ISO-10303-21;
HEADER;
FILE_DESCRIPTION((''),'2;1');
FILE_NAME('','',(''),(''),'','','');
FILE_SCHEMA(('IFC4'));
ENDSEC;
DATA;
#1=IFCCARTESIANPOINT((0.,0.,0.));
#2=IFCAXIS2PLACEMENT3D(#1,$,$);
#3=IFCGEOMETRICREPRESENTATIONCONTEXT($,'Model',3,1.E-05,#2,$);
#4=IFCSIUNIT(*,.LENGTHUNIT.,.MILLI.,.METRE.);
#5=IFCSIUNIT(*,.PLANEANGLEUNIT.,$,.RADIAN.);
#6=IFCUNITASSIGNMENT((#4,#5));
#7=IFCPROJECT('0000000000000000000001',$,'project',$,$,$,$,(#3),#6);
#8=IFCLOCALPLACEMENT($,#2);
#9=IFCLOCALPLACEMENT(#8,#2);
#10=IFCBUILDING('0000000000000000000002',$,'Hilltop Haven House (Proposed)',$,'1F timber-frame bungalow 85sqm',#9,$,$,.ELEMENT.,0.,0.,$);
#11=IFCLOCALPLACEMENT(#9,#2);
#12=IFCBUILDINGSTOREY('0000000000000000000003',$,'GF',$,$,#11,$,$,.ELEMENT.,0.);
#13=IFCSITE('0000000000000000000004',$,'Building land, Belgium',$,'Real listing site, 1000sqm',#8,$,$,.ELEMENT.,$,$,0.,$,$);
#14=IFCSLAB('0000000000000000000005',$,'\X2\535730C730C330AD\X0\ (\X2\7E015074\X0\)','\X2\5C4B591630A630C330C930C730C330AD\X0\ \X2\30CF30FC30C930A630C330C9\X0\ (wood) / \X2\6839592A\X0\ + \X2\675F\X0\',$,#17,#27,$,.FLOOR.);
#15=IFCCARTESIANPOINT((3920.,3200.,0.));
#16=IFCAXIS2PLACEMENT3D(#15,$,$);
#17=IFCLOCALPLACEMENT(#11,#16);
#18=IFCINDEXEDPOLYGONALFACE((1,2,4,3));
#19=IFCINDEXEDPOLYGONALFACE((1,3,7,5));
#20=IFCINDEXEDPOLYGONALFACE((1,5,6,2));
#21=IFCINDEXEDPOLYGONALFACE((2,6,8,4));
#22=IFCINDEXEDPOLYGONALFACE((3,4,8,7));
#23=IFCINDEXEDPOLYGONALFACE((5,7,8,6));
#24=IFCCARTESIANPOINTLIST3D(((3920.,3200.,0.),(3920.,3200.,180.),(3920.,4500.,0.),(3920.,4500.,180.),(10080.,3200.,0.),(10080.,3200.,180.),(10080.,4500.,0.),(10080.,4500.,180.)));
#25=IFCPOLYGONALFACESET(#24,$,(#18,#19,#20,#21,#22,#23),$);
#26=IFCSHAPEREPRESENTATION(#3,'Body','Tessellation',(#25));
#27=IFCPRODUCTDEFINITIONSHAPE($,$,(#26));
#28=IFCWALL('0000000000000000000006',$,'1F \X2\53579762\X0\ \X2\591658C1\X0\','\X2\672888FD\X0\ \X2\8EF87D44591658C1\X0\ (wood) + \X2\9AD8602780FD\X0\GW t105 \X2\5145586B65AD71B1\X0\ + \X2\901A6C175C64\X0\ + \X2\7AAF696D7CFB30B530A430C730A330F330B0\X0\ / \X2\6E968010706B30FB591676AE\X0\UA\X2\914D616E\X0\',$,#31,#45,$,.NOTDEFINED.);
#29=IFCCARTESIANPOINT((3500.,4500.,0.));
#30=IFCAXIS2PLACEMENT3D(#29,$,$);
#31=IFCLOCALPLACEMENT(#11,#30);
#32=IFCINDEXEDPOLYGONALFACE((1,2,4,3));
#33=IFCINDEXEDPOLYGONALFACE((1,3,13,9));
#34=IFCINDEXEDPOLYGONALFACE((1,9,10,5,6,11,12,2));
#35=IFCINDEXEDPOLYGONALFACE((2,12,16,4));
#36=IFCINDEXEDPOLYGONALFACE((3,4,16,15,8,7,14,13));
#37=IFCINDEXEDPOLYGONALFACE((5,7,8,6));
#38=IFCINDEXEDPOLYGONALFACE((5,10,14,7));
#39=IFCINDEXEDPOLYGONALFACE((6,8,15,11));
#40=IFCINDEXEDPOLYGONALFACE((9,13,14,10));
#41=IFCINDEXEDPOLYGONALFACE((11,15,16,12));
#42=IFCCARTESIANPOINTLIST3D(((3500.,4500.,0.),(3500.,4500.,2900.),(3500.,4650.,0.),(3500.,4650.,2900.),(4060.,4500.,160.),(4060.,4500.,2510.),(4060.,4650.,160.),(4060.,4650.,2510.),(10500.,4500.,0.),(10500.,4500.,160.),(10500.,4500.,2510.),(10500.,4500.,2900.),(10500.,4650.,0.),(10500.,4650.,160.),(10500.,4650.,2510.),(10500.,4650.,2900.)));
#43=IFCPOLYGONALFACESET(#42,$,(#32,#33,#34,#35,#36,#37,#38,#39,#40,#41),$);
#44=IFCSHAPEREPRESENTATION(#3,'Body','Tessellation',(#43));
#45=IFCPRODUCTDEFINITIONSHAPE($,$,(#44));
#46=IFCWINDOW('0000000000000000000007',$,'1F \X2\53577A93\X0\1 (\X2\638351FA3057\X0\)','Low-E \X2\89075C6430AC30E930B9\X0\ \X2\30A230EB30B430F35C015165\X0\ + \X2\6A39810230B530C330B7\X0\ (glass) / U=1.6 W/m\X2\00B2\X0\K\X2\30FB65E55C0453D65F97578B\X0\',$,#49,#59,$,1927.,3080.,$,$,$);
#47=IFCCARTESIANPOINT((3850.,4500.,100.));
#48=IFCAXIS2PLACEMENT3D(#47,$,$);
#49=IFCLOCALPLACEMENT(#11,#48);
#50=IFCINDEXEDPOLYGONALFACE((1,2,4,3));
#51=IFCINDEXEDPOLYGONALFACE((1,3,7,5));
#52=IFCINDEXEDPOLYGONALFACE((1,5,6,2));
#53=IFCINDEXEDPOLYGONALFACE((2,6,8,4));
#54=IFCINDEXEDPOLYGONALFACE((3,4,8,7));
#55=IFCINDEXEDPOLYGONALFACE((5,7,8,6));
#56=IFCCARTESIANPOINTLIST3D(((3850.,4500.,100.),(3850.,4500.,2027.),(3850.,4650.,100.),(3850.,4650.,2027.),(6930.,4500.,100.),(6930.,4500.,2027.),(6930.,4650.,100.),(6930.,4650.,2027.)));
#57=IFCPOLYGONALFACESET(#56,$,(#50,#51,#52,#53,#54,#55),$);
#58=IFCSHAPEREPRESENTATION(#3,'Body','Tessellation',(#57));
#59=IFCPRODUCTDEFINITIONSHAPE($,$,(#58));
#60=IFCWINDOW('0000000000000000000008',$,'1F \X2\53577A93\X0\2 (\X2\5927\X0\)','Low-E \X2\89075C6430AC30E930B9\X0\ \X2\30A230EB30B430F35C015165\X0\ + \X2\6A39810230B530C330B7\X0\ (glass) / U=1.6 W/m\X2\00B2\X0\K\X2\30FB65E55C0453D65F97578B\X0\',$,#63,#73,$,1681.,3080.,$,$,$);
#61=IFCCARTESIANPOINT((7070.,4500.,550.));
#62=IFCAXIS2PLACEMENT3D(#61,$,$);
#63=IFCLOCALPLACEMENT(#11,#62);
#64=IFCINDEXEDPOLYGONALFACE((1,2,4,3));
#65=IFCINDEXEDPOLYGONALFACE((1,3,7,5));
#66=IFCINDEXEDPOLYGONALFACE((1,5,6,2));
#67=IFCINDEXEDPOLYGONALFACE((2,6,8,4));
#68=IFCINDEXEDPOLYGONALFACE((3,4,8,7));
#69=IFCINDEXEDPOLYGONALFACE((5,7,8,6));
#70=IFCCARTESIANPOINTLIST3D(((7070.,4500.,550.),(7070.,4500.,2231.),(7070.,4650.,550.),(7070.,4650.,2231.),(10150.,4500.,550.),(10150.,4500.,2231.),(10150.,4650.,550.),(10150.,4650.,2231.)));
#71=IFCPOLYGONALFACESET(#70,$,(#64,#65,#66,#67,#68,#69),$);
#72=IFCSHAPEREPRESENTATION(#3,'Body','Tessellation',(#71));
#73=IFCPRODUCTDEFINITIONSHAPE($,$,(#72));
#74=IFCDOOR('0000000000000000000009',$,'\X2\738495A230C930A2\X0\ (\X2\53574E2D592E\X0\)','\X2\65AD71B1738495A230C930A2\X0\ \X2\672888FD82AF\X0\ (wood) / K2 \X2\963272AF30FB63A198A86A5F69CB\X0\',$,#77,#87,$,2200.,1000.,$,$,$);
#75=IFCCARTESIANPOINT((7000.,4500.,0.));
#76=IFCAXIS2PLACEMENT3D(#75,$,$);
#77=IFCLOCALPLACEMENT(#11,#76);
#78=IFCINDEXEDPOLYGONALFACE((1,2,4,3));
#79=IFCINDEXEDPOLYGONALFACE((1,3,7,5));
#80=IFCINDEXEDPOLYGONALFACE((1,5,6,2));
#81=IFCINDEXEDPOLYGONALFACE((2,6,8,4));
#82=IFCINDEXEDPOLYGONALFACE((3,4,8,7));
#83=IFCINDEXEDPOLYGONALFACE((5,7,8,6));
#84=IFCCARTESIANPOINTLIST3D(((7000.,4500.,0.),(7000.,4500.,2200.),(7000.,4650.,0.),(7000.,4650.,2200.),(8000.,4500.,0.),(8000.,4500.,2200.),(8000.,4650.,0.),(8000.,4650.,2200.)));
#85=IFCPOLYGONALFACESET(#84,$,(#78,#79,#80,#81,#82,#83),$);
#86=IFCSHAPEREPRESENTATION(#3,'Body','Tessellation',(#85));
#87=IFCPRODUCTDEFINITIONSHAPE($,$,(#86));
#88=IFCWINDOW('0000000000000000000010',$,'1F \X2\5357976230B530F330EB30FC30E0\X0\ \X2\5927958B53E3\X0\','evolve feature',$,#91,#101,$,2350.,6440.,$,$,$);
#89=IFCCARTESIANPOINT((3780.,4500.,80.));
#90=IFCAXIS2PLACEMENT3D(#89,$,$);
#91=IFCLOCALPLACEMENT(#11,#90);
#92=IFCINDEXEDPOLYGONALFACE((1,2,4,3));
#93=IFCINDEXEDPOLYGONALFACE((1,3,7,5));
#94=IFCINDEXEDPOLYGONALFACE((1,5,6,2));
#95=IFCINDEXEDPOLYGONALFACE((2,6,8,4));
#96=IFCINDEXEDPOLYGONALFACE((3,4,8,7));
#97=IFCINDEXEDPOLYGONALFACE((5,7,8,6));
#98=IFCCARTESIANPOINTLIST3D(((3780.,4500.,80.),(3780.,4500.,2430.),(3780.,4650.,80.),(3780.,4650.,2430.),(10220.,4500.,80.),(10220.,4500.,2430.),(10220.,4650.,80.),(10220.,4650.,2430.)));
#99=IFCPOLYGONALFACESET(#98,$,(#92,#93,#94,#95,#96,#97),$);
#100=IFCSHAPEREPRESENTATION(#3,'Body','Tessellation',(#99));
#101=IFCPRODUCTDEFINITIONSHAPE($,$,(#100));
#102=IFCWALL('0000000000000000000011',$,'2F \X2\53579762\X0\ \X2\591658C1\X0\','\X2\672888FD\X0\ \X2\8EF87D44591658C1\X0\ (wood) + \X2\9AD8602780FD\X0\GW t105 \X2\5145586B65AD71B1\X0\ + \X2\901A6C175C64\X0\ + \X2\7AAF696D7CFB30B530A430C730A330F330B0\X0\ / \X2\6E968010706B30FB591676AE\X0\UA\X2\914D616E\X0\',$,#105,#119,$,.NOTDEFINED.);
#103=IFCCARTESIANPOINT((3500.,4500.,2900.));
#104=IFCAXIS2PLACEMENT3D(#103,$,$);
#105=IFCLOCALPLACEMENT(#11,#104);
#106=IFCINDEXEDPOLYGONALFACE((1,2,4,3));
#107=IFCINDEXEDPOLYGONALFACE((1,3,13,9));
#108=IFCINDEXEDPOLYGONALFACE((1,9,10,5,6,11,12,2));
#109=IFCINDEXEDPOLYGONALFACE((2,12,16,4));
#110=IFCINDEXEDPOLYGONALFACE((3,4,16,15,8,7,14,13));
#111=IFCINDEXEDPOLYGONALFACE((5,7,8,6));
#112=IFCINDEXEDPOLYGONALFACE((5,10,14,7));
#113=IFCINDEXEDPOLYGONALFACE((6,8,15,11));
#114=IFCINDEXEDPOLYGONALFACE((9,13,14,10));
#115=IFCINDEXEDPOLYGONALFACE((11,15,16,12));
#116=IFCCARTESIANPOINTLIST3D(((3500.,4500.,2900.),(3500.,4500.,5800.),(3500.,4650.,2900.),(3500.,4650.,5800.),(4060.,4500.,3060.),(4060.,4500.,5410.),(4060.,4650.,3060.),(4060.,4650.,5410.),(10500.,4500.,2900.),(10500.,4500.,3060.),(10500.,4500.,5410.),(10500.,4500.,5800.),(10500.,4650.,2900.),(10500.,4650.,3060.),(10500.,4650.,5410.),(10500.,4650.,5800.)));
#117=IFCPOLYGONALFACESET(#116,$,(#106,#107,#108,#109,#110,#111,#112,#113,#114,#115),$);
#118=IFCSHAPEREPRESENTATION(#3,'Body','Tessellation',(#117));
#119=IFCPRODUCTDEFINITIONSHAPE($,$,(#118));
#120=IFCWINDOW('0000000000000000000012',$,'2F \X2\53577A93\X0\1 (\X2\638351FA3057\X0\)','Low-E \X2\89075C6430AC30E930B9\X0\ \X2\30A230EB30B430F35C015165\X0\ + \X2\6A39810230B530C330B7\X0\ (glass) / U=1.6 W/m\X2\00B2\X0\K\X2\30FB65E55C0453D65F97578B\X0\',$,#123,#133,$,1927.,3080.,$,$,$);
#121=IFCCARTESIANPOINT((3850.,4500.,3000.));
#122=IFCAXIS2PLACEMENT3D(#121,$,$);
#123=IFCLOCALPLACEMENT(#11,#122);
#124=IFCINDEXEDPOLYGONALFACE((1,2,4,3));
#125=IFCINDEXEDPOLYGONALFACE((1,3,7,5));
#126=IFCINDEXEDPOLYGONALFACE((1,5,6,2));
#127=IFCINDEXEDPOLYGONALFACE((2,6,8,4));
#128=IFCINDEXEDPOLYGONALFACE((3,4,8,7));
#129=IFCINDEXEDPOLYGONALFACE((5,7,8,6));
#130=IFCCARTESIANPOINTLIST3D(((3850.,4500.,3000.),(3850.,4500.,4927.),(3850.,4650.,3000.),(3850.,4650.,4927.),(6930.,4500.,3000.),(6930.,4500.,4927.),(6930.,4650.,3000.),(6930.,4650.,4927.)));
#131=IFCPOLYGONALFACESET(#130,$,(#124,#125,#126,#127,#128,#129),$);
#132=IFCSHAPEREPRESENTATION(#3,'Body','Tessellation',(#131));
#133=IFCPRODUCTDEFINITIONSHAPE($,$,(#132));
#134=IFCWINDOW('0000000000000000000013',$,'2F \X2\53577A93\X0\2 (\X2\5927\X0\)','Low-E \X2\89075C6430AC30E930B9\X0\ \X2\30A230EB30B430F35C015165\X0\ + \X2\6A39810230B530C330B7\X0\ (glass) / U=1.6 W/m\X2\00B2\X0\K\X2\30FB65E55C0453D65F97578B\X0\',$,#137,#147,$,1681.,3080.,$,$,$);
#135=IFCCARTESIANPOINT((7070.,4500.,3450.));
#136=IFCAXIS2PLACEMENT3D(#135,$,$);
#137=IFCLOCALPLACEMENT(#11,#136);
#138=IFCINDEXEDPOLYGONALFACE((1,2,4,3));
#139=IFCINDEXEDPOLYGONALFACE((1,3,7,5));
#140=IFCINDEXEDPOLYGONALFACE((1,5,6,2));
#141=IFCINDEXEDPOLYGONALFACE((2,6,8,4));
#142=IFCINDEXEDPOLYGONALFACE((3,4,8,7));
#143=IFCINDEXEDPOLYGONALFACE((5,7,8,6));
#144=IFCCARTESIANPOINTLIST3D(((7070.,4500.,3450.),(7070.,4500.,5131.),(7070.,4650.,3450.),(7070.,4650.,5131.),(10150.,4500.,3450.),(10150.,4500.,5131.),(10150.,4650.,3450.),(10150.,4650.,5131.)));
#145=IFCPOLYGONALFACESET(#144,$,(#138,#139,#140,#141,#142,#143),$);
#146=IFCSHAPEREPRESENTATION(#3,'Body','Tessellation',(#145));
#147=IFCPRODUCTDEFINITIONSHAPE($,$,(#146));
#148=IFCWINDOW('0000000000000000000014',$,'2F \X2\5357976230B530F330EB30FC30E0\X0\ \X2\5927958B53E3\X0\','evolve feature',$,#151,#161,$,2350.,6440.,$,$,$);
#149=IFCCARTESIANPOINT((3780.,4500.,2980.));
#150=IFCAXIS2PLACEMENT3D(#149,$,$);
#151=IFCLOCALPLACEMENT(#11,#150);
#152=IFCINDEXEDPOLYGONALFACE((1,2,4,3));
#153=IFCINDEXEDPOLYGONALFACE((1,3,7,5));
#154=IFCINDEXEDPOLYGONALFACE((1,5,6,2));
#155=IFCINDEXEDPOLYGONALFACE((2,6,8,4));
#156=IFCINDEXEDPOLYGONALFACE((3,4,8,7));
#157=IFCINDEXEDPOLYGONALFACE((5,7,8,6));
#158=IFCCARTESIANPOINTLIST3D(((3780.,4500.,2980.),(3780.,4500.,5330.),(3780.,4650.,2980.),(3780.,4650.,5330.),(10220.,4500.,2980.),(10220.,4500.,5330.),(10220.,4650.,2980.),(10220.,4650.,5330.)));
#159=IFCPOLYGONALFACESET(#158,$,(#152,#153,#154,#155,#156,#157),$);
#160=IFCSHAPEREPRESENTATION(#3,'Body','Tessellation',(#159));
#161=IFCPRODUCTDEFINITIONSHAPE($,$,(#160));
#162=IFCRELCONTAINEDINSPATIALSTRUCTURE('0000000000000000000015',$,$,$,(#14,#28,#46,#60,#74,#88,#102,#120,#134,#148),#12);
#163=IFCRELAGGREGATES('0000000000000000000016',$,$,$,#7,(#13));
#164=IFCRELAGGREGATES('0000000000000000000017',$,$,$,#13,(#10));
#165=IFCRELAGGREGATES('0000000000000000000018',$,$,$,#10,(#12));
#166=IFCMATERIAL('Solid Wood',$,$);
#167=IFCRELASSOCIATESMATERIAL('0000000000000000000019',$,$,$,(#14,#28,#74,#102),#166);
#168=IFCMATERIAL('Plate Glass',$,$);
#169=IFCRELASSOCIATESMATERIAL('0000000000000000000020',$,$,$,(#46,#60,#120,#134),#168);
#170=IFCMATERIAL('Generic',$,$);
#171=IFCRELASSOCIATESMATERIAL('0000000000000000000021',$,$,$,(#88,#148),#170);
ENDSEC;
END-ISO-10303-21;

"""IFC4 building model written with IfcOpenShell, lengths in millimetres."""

from ifc_helpers import new_model, si_unit, frame, frame_2d, origin, place, context, project, spatial, rectangle, extrude, material, element, fill, save


model = new_model("IFC4")

# Units and contexts
model_context = context("Model", 3, precision=1e-05, world=origin())
ifc_project = project(units=[si_unit("LENGTHUNIT", "METRE", prefix="MILLI"), si_unit("PLANEANGLEUNIT", "RADIAN")], contexts=[model_context])

# Site, building, storey
site_placement = place(None, origin())
site = spatial("IfcSite", under=ifc_project, at=site_placement, Name="Building land, Belgium", ObjectType="Real listing site, 1000sqm", CompositionType="ELEMENT", RefElevation=0.0)
building_placement = place(site_placement, origin())
building = spatial("IfcBuilding", under=site, at=building_placement, Name="Hilltop Haven House (Proposed)", ObjectType="1F timber-frame bungalow 85sqm", CompositionType="ELEMENT", ElevationOfRefHeight=0.0, ElevationOfTerrain=0.0)
storey_placement = place(building_placement, origin())
storey = spatial("IfcBuildingStorey", under=building, at=storey_placement, Name="GF", CompositionType="ELEMENT", Elevation=0.0)

# Slab
ifc_material_1 = material(Name="Solid Wood")
slab_1_placement = place(storey_placement, frame((3920.0, 3200.0, 0.0)))
element("IfcSlab", 1, at=slab_1_placement, inside=storey, material=ifc_material_1, Name="南デッキ (縁側)", Description="屋外ウッドデッキ ハードウッド (wood) / 根太 + 束", PredefinedType="FLOOR", context=model_context, shape_type="SweptSolid", body=[
    extrude(rectangle(XDim=6160.0, YDim=1300.0, at=frame_2d((3080.0, 650.0))), frame((3920.0, 3200.0, 0.0)), (0.0, 0.0, 1.0), 180.0),
])
ifc_material_2 = material(Name="Generic")

# Wall, openings, windows, door
wall_1_placement = place(storey_placement, frame((3500.0, 4500.0, 0.0)))
wall_1 = element("IfcWall", 2, at=wall_1_placement, inside=storey, material=ifc_material_1, Name="1F 南面 外壁", Description="木製 軸組外壁 (wood) + 高性能GW t105 充填断熱 + 通気層 + 窯業系サイディング / 準耐火・外皮UA配慮", PredefinedType="NOTDEFINED", context=model_context, shape_type="SweptSolid", body=[
    extrude(rectangle(XDim=7000.0, YDim=150.0, at=frame_2d((3500.0, 75.0))), frame((3500.0, 4500.0, 0.0)), (0.0, 0.0, 1.0), 2900.0),
])
opening_1_placement = place(storey_placement, frame((3850.0, 4500.0, 100.0)))
opening_1 = element("IfcOpeningElement", 3, at=opening_1_placement, cuts=wall_1, PredefinedType="NOTDEFINED", context=model_context, shape_type="SweptSolid", body=[
    extrude(rectangle(XDim=3080.0, YDim=150.0, at=frame_2d((1540.0, 75.0))), frame((3850.0, 4500.0, 100.0)), (0.0, 0.0, 1.0), 1927.0),
])
opening_2_placement = place(storey_placement, frame((7070.0, 4500.0, 550.0)))
opening_2 = element("IfcOpeningElement", 4, at=opening_2_placement, cuts=wall_1, PredefinedType="NOTDEFINED", context=model_context, shape_type="SweptSolid", body=[
    extrude(rectangle(XDim=3080.0, YDim=150.0, at=frame_2d((1540.0, 75.0))), frame((7070.0, 4500.0, 550.0)), (0.0, 0.0, 1.0), 1681.0),
])
opening_3_placement = place(storey_placement, frame((7000.0, 4500.0, 0.0)))
opening_3 = element("IfcOpeningElement", 5, at=opening_3_placement, cuts=wall_1, PredefinedType="NOTDEFINED", context=model_context, shape_type="SweptSolid", body=[
    extrude(rectangle(XDim=1000.0, YDim=150.0, at=frame_2d((500.0, 75.0))), frame((7000.0, 4500.0, 0.0)), (0.0, 0.0, 1.0), 2200.0),
])
opening_4_placement = place(storey_placement, frame((3780.0, 4500.0, 80.0)))
opening_4 = element("IfcOpeningElement", 6, at=opening_4_placement, cuts=wall_1, PredefinedType="NOTDEFINED", context=model_context, shape_type="SweptSolid", body=[
    extrude(rectangle(XDim=6440.0, YDim=150.0, at=frame_2d((3220.0, 75.0))), frame((3780.0, 4500.0, 80.0)), (0.0, 0.0, 1.0), 2350.0),
])
ifc_material_3 = material(Name="Plate Glass")
window_1_placement = place(storey_placement, frame((3850.0, 4500.0, 100.0)))
window_1 = element("IfcWindow", 7, at=window_1_placement, inside=storey, material=ifc_material_3, Name="1F 南窓1 (掃出し)", Description="Low-E 複層ガラス アルゴン封入 + 樹脂サッシ (glass) / U=1.6 W/m²K・日射取得型", OverallHeight=1927.0, OverallWidth=3080.0, context=model_context, shape_type="SweptSolid", body=[
    extrude(rectangle(XDim=3080.0, YDim=150.0, at=frame_2d((1540.0, 75.0))), frame((3850.0, 4500.0, 100.0)), (0.0, 0.0, 1.0), 1927.0),
])
fill(opening_1, window_1)
window_2_placement = place(storey_placement, frame((7070.0, 4500.0, 550.0)))
window_2 = element("IfcWindow", 8, at=window_2_placement, inside=storey, material=ifc_material_3, Name="1F 南窓2 (大)", Description="Low-E 複層ガラス アルゴン封入 + 樹脂サッシ (glass) / U=1.6 W/m²K・日射取得型", OverallHeight=1681.0, OverallWidth=3080.0, context=model_context, shape_type="SweptSolid", body=[
    extrude(rectangle(XDim=3080.0, YDim=150.0, at=frame_2d((1540.0, 75.0))), frame((7070.0, 4500.0, 550.0)), (0.0, 0.0, 1.0), 1681.0),
])
fill(opening_2, window_2)
door_placement = place(storey_placement, frame((7000.0, 4500.0, 0.0)))
door = element("IfcDoor", 9, at=door_placement, inside=storey, material=ifc_material_1, Name="玄関ドア (南中央)", Description="断熱玄関ドア 木製芯 (wood) / K2 防犯・採風機構", OverallHeight=2200.0, OverallWidth=1000.0, context=model_context, shape_type="SweptSolid", body=[
    extrude(rectangle(XDim=1000.0, YDim=150.0, at=frame_2d((500.0, 75.0))), frame((7000.0, 4500.0, 0.0)), (0.0, 0.0, 1.0), 2200.0),
])
fill(opening_3, door)
window_3_placement = place(storey_placement, frame((3780.0, 4500.0, 80.0)))
window_3 = element("IfcWindow", 10, at=window_3_placement, inside=storey, material=ifc_material_2, Name="1F 南面サンルーム 大開口", Description="evolve feature", OverallHeight=2350.0, OverallWidth=6440.0, context=model_context, shape_type="SweptSolid", body=[
    extrude(rectangle(XDim=6440.0, YDim=150.0, at=frame_2d((3220.0, 75.0))), frame((3780.0, 4500.0, 80.0)), (0.0, 0.0, 1.0), 2350.0),
])
fill(opening_4, window_3)

# Wall, openings, windows
wall_2_placement = place(storey_placement, frame((3500.0, 4500.0, 2900.0)))
wall_2 = element("IfcWall", 11, at=wall_2_placement, inside=storey, material=ifc_material_1, Name="2F 南面 外壁", Description="木製 軸組外壁 (wood) + 高性能GW t105 充填断熱 + 通気層 + 窯業系サイディング / 準耐火・外皮UA配慮", PredefinedType="NOTDEFINED", context=model_context, shape_type="SweptSolid", body=[
    extrude(rectangle(XDim=7000.0, YDim=150.0, at=frame_2d((3500.0, 75.0))), frame((3500.0, 4500.0, 2900.0)), (0.0, 0.0, 1.0), 2900.0),
])
opening_5_placement = place(storey_placement, frame((3850.0, 4500.0, 3000.0)))
opening_5 = element("IfcOpeningElement", 12, at=opening_5_placement, cuts=wall_2, PredefinedType="NOTDEFINED", context=model_context, shape_type="SweptSolid", body=[
    extrude(rectangle(XDim=3080.0, YDim=150.0, at=frame_2d((1540.0, 75.0))), frame((3850.0, 4500.0, 3000.0)), (0.0, 0.0, 1.0), 1927.0),
])
opening_6_placement = place(storey_placement, frame((7070.0, 4500.0, 3450.0)))
opening_6 = element("IfcOpeningElement", 13, at=opening_6_placement, cuts=wall_2, PredefinedType="NOTDEFINED", context=model_context, shape_type="SweptSolid", body=[
    extrude(rectangle(XDim=3080.0, YDim=150.0, at=frame_2d((1540.0, 75.0))), frame((7070.0, 4500.0, 3450.0)), (0.0, 0.0, 1.0), 1681.0),
])
opening_7_placement = place(storey_placement, frame((3780.0, 4500.0, 2980.0)))
opening_7 = element("IfcOpeningElement", 14, at=opening_7_placement, cuts=wall_2, PredefinedType="NOTDEFINED", context=model_context, shape_type="SweptSolid", body=[
    extrude(rectangle(XDim=6440.0, YDim=150.0, at=frame_2d((3220.0, 75.0))), frame((3780.0, 4500.0, 2980.0)), (0.0, 0.0, 1.0), 2350.0),
])
window_4_placement = place(storey_placement, frame((3850.0, 4500.0, 3000.0)))
window_4 = element("IfcWindow", 15, at=window_4_placement, inside=storey, material=ifc_material_3, Name="2F 南窓1 (掃出し)", Description="Low-E 複層ガラス アルゴン封入 + 樹脂サッシ (glass) / U=1.6 W/m²K・日射取得型", OverallHeight=1927.0, OverallWidth=3080.0, context=model_context, shape_type="SweptSolid", body=[
    extrude(rectangle(XDim=3080.0, YDim=150.0, at=frame_2d((1540.0, 75.0))), frame((3850.0, 4500.0, 3000.0)), (0.0, 0.0, 1.0), 1927.0),
])
fill(opening_5, window_4)
window_5_placement = place(storey_placement, frame((7070.0, 4500.0, 3450.0)))
window_5 = element("IfcWindow", 16, at=window_5_placement, inside=storey, material=ifc_material_3, Name="2F 南窓2 (大)", Description="Low-E 複層ガラス アルゴン封入 + 樹脂サッシ (glass) / U=1.6 W/m²K・日射取得型", OverallHeight=1681.0, OverallWidth=3080.0, context=model_context, shape_type="SweptSolid", body=[
    extrude(rectangle(XDim=3080.0, YDim=150.0, at=frame_2d((1540.0, 75.0))), frame((7070.0, 4500.0, 3450.0)), (0.0, 0.0, 1.0), 1681.0),
])
fill(opening_6, window_5)
window_6_placement = place(storey_placement, frame((3780.0, 4500.0, 2980.0)))
window_6 = element("IfcWindow", 17, at=window_6_placement, inside=storey, material=ifc_material_2, Name="2F 南面サンルーム 大開口", Description="evolve feature", OverallHeight=2350.0, OverallWidth=6440.0, context=model_context, shape_type="SweptSolid", body=[
    extrude(rectangle(XDim=6440.0, YDim=150.0, at=frame_2d((3220.0, 75.0))), frame((3780.0, 4500.0, 2980.0)), (0.0, 0.0, 1.0), 2350.0),
])
fill(opening_7, window_6)

save(model, "model.ifc")
